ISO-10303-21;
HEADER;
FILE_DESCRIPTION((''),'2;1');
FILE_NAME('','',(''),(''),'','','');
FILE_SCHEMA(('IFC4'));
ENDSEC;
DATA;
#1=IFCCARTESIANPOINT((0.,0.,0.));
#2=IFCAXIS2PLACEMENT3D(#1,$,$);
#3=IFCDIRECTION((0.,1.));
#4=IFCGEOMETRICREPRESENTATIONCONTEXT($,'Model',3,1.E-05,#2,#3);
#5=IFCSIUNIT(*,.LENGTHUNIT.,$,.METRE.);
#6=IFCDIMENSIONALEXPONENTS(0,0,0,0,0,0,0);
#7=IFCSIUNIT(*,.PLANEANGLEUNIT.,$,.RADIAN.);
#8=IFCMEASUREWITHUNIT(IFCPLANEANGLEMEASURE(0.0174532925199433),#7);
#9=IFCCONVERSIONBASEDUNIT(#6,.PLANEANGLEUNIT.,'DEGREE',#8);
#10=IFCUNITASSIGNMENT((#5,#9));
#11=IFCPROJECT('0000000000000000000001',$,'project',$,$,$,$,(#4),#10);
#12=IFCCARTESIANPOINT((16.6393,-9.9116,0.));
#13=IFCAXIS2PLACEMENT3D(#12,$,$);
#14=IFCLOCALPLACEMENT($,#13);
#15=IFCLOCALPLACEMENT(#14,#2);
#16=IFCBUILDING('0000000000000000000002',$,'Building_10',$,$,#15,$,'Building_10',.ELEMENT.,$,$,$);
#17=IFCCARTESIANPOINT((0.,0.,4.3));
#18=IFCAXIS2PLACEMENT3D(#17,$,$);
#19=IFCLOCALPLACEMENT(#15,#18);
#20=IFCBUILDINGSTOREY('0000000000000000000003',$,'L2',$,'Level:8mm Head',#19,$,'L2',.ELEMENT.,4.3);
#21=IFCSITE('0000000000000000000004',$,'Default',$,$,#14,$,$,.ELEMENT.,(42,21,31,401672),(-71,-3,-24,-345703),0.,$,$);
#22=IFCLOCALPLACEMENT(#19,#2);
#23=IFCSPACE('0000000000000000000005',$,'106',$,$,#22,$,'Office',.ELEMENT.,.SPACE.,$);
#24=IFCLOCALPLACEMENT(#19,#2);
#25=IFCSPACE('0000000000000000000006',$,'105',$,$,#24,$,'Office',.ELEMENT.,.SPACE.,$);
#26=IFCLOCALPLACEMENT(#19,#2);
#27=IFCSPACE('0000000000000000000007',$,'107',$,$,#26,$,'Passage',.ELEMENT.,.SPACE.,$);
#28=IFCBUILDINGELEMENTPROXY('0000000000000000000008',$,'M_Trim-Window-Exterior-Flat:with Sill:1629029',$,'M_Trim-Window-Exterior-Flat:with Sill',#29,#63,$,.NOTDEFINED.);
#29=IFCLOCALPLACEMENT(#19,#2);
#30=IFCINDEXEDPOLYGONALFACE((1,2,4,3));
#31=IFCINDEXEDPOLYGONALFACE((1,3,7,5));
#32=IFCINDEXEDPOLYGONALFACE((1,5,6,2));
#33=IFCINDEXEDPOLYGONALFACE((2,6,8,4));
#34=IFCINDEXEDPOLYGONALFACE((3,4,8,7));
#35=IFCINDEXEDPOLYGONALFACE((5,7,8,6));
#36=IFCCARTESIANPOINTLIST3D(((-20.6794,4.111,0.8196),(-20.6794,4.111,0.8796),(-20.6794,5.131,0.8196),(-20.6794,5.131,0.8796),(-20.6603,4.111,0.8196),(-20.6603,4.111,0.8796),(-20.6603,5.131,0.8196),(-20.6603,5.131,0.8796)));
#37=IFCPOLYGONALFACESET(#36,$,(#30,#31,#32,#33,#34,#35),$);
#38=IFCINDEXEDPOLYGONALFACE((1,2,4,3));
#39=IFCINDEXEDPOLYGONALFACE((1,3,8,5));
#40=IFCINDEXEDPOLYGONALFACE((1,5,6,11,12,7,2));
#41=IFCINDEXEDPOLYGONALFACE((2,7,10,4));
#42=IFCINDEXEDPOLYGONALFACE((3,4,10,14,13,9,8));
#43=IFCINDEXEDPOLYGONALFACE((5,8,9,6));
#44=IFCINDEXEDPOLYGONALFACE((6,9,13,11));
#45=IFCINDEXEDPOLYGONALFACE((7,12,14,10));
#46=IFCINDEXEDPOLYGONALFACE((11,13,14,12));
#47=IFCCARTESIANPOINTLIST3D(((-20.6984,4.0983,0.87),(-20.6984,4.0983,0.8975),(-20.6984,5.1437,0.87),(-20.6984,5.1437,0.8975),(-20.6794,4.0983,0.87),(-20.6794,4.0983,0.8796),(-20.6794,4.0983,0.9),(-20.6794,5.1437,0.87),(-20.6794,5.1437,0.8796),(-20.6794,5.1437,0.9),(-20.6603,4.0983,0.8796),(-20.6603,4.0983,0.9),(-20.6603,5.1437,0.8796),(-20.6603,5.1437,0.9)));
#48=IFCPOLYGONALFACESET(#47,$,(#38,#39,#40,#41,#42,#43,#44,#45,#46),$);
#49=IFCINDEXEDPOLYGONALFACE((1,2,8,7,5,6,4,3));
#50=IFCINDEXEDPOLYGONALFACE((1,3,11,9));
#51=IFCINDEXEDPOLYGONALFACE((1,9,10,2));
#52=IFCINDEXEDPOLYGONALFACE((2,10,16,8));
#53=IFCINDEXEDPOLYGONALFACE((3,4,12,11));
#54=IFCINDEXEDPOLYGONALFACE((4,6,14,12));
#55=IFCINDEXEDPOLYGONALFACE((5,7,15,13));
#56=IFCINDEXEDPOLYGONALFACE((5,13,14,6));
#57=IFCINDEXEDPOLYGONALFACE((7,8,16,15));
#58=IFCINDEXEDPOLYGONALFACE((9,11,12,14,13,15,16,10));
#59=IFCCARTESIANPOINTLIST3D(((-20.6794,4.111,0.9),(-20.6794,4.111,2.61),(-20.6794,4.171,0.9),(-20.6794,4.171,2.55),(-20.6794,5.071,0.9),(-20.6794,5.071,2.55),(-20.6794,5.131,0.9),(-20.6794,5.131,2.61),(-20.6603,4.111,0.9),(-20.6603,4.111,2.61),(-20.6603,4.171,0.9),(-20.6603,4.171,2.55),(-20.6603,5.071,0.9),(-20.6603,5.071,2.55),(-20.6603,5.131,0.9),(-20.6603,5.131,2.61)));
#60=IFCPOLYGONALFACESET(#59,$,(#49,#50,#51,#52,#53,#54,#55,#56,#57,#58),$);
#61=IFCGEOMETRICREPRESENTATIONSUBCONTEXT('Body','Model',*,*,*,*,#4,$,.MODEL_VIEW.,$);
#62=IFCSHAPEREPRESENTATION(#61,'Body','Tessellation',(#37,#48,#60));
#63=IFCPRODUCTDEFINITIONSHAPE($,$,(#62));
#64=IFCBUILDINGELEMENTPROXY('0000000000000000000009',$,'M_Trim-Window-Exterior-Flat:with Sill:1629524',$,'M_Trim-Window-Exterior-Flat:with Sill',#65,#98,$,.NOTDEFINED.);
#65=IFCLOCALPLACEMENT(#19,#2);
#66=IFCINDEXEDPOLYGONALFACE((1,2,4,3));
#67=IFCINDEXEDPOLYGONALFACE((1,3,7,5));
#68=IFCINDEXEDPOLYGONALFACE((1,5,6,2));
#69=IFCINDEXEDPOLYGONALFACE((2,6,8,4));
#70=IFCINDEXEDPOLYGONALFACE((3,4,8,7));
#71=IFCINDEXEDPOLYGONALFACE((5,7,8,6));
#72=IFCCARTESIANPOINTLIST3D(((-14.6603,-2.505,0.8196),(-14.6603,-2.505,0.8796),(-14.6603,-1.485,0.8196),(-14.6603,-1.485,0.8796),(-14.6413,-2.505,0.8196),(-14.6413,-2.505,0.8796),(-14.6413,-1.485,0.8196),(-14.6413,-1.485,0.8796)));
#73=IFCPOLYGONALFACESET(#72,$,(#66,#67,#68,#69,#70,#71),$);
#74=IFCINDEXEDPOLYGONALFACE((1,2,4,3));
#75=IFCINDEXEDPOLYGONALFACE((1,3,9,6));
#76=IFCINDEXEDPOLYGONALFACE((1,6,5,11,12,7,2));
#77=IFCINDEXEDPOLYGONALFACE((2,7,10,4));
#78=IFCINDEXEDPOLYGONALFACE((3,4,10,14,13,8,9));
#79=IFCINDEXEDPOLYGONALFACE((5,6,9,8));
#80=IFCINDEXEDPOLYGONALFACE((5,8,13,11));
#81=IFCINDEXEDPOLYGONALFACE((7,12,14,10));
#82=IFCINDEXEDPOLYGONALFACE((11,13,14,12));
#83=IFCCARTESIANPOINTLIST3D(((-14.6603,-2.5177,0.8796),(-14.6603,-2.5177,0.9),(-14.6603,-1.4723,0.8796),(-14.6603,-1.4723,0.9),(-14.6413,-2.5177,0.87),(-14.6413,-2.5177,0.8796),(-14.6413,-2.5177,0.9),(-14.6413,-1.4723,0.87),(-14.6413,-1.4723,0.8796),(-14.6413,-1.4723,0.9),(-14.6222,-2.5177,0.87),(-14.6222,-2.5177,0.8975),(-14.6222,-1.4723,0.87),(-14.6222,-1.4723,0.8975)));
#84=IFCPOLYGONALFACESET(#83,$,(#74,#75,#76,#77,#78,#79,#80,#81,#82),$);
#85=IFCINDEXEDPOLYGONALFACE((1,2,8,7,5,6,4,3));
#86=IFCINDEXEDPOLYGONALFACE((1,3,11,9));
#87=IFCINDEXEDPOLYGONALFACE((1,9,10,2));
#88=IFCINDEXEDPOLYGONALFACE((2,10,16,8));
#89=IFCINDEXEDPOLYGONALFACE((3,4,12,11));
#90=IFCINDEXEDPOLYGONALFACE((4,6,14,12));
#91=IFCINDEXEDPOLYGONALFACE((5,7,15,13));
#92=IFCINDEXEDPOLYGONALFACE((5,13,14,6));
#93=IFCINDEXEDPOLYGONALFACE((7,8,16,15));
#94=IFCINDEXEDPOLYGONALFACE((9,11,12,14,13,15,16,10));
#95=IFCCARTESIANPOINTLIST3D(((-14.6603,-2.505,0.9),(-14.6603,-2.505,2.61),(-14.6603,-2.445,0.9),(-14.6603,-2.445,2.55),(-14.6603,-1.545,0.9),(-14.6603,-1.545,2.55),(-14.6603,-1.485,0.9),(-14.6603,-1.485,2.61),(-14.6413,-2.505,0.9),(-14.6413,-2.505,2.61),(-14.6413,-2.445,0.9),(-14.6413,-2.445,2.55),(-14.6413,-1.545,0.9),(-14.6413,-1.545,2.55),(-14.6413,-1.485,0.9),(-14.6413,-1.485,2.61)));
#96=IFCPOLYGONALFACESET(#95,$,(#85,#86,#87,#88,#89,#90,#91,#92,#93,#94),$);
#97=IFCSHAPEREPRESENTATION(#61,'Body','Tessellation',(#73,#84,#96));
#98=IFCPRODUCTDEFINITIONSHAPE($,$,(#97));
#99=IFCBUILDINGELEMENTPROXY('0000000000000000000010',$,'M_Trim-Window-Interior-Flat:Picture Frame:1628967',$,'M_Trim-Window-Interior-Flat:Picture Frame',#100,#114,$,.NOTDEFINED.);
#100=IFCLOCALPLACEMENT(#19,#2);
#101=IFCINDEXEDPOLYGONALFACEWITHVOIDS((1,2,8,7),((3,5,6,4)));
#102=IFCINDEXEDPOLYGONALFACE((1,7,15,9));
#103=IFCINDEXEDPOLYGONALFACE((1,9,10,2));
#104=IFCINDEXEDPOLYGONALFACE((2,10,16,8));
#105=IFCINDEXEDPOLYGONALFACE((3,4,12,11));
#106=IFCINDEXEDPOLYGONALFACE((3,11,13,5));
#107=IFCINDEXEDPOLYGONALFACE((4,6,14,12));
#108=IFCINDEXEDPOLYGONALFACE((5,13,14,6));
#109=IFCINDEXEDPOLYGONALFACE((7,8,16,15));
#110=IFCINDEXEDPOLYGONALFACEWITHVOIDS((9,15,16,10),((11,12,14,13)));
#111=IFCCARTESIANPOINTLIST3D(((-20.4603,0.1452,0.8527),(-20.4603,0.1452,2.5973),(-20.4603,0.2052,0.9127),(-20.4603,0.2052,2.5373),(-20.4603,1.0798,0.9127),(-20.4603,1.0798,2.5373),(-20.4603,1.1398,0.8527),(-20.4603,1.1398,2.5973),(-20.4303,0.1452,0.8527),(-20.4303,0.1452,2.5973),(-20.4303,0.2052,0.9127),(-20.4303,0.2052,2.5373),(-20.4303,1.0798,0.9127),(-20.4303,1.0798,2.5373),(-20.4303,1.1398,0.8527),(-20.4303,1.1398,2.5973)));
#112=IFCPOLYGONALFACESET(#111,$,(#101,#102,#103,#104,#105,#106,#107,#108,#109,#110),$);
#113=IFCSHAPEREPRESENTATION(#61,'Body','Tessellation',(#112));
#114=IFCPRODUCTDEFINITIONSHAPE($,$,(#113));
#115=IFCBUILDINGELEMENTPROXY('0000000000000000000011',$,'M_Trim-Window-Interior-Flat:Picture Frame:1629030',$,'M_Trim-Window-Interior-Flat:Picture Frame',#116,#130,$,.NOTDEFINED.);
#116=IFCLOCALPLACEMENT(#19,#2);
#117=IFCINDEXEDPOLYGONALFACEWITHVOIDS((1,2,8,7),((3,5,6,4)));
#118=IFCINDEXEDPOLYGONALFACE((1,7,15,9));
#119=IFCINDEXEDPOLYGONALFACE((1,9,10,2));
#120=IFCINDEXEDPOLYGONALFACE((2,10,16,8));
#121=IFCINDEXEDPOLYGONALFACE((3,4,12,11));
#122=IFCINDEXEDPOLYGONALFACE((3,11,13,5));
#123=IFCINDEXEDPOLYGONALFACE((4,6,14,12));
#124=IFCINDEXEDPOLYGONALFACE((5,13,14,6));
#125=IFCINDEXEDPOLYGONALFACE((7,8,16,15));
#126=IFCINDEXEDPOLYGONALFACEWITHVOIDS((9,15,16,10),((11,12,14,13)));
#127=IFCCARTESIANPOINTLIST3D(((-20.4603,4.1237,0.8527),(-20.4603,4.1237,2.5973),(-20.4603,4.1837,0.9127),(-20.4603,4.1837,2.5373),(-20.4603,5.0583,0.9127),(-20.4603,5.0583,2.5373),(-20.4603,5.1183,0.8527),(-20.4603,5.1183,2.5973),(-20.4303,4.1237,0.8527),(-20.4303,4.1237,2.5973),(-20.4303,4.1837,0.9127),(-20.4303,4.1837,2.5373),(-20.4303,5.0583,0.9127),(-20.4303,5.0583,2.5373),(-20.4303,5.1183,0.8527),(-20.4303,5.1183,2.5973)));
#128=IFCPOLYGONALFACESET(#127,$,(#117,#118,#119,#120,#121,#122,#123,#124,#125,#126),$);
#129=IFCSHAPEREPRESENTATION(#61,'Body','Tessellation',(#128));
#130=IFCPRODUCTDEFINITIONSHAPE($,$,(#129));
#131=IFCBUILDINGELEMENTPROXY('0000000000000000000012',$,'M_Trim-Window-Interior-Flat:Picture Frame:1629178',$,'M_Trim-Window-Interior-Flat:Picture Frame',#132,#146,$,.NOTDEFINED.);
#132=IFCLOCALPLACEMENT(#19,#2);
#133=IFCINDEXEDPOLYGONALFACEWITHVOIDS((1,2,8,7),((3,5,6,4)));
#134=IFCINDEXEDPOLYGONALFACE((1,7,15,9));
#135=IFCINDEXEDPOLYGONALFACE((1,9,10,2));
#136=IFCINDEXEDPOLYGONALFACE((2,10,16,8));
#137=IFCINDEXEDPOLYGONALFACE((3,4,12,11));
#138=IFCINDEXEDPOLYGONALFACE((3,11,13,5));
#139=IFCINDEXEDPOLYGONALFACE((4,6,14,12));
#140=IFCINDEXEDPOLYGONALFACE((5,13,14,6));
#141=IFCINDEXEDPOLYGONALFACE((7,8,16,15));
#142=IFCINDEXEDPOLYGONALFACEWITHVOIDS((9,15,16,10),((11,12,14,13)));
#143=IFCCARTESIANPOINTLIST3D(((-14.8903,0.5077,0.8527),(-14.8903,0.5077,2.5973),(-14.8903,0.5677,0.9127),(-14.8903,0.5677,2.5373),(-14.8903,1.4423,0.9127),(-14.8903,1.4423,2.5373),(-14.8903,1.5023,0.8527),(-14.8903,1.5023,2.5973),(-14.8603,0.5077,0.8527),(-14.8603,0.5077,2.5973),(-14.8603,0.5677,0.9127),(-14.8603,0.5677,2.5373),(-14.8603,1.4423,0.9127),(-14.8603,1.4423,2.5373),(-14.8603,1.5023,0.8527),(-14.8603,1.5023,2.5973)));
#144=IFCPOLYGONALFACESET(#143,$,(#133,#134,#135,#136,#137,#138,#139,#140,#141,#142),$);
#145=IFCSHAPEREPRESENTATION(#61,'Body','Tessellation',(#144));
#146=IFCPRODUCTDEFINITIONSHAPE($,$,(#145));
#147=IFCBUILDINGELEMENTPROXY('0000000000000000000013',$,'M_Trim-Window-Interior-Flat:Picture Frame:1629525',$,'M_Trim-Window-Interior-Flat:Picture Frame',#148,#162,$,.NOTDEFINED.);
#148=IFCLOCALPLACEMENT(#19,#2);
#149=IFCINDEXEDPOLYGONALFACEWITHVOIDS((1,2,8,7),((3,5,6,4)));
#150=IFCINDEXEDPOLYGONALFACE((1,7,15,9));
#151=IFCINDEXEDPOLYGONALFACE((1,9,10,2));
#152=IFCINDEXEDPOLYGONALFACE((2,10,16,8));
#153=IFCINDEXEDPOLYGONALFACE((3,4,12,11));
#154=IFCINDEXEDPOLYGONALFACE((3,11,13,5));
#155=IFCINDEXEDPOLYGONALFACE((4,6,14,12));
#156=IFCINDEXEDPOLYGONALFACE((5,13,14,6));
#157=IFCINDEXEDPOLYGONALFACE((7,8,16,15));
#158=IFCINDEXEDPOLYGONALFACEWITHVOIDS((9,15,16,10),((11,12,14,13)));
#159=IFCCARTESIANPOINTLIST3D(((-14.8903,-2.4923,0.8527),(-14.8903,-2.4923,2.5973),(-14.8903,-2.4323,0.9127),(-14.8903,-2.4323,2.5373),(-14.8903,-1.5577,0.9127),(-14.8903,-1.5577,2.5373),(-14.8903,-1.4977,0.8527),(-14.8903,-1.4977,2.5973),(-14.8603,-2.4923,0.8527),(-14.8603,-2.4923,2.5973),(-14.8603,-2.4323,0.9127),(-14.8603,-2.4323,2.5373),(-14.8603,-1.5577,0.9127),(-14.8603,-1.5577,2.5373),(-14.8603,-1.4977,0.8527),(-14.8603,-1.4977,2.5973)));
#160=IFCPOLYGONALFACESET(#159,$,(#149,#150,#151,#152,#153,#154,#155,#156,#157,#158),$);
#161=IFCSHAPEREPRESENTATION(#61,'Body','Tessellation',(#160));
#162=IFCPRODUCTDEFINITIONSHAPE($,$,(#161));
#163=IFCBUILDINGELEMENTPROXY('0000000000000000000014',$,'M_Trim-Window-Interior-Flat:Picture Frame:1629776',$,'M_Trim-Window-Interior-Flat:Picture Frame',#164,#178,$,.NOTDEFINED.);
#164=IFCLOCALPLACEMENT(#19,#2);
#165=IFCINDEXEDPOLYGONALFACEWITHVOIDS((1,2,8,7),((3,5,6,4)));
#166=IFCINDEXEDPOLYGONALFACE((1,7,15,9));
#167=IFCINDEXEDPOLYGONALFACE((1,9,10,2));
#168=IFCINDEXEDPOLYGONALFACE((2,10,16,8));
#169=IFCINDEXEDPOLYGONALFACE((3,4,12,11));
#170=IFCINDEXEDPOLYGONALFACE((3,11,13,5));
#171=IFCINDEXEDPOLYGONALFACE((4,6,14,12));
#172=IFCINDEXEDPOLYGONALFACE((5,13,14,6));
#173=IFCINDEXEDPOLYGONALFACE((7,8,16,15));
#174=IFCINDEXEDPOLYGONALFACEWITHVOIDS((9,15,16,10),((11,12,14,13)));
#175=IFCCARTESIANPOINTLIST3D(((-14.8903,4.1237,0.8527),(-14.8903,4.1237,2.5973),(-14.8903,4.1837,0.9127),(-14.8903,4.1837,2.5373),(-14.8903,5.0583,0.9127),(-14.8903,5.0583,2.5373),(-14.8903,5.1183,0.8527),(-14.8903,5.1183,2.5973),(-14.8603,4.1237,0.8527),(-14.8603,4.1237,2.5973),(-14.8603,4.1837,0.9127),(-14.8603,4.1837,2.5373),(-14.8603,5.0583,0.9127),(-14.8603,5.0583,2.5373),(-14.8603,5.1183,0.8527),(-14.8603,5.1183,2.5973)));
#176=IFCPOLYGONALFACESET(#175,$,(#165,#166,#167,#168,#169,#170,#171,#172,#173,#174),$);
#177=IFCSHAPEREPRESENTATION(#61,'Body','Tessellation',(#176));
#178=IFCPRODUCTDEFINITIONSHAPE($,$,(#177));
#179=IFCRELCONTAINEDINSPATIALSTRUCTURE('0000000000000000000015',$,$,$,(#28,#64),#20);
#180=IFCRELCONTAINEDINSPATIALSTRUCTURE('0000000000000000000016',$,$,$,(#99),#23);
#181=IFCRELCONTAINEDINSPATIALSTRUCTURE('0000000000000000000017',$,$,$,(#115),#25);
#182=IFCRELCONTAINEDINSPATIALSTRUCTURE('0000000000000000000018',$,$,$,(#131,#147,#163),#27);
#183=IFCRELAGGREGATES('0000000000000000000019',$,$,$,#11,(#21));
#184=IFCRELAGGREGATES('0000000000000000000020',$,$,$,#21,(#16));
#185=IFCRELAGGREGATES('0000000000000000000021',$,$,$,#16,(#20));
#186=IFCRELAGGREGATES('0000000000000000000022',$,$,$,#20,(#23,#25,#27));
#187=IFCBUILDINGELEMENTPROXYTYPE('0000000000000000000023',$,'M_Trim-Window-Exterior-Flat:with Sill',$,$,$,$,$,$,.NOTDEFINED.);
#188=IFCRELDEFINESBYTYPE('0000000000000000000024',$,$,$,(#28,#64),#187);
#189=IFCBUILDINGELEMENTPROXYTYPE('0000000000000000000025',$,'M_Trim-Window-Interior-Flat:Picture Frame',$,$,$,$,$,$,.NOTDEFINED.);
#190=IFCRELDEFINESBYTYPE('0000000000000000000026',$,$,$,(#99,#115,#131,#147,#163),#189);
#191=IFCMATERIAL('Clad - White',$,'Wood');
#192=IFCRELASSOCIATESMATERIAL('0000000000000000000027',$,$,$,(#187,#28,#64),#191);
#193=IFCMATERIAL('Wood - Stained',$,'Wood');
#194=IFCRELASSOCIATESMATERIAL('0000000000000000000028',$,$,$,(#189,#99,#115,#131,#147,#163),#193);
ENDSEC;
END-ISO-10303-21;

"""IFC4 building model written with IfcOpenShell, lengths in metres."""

from ifc_helpers import new_model, entity, si_unit, converted_unit, direction, frame, origin, place, context, subcontext, project, spatial, indexed_curve, outline, extrude, source, transform, mapped, material, type_object, type_shapes, element, save


model = new_model("IFC4")

# Units and contexts
model_context = context("Model", 3, precision=1e-05, world=origin(), true_north=direction((0.0, 1.0)))
body_context = subcontext(model_context, "Body", "Model", "MODEL_VIEW")
ifc_project = project(units=[si_unit("LENGTHUNIT", "METRE"), converted_unit("PLANEANGLEUNIT", "DEGREE", entity("IfcPlaneAngleMeasure", 0.0174532925199433), si_unit("PLANEANGLEUNIT", "RADIAN"), dimensions=[0, 0, 0, 0, 0, 0, 0])], contexts=[model_context])

# Site, building, storey
site_placement = place(None, frame((16.6393, -9.9116, 0.0)))
site = spatial("IfcSite", under=ifc_project, at=site_placement, Name="Default", CompositionType="ELEMENT", RefLatitude=(42, 21, 31, 401672), RefLongitude=(-71, -3, -24, -345703), RefElevation=0.0)
building_placement = place(site_placement, origin())
building = spatial("IfcBuilding", under=site, at=building_placement, Name="Building_10", LongName="Building_10", CompositionType="ELEMENT")
storey_placement = place(building_placement, frame((0.0, 0.0, 4.3)))
storey = spatial("IfcBuildingStorey", under=building, at=storey_placement, Name="L2", ObjectType="Level:8mm Head", LongName="L2", CompositionType="ELEMENT", Elevation=4.3)

# Shared definitions
ifc_material_1 = material(Name="Clad - White", Category="Wood")
ifc_material_2 = material(Name="Wood - Stained", Category="Wood")

# Building element proxies
building_element_proxy_type_1 = type_object("IfcBuildingElementProxyType", Name="M_Trim-Window-Exterior-Flat:with Sill", PredefinedType="NOTDEFINED", material=ifc_material_1)
shared_shape_1 = source(origin(), body_context, "Body", "SweptSolid", [
    extrude(outline(indexed_curve([(-0.51, -0.03), (0.51, -0.03), (0.51, 0.03), (-0.51, 0.03), (-0.51, -0.03)], self_intersect=False)), frame((0.0, -1.7004, 0.0), z_axis=(0.0, 0.0, 1.0), x_axis=(-1.0, 0.0, 0.0)), (0.0, 0.0, 1.0), 0.0191),
    extrude(outline(indexed_curve([(-0.019, -0.0152), (0.0, -0.0152), (0.0, -0.0057), (0.019, -0.0057), (0.019, 0.0148), (0.0, 0.0148), (-0.019, 0.0123), (-0.019, -0.0152)], self_intersect=False)), frame((-0.5227, -1.6648, 0.019), z_axis=(1.0, 0.0, 0.0), x_axis=(0.0, 0.0, -1.0)), (0.0, 0.0, 1.0), 1.0454),
    extrude(outline(indexed_curve([(-0.87, -0.51), (0.84, -0.51), (0.84, -0.45), (-0.81, -0.45), (-0.81, 0.45), (0.84, 0.45), (0.84, 0.51), (-0.87, 0.51), (-0.87, -0.51)], self_intersect=False)), frame((0.0, -0.81, 0.0), z_axis=(0.0, 0.0, 1.0), x_axis=(0.0, -1.0, 0.0)), (0.0, 0.0, 1.0), 0.0191),
])
type_shapes(building_element_proxy_type_1, [shared_shape_1])
for number, where, z_axis, x_axis, name in (
    (1, (-20.6603, 4.621, 2.55), (-1.0, 0.0, 0.0), (0.0, -1.0, 0.0), "M_Trim-Window-Exterior-Flat:with Sill:1629029"),
    (2, (-14.6603, -1.995, 2.55), (1.0, 0.0, 0.0), (0.0, 1.0, 0.0), "M_Trim-Window-Exterior-Flat:with Sill:1629524"),
):
    element("IfcBuildingElementProxy", number, at=place(storey_placement, frame(where, z_axis=z_axis, x_axis=x_axis)), inside=storey, type_object=building_element_proxy_type_1, material=ifc_material_1, Name=name, ObjectType="M_Trim-Window-Exterior-Flat:with Sill", PredefinedType="NOTDEFINED", context=body_context, shape_type="MappedRepresentation", body=[
        mapped(shared_shape_1, transform((0.0, 0.0, 0.0), scale=1.0)),
    ])

# Shared definitions
space_1_placement = place(storey_placement, origin())
space_1 = spatial("IfcSpace", under=storey, at=space_1_placement, Name="106", LongName="Office", CompositionType="ELEMENT", PredefinedType="SPACE")

# Building element proxy
building_element_proxy_type_2 = type_object("IfcBuildingElementProxyType", Name="M_Trim-Window-Interior-Flat:Picture Frame", PredefinedType="NOTDEFINED", material=ifc_material_2)
shared_shape_2 = source(origin(), body_context, "Body", "SweptSolid", [
    extrude(outline(indexed_curve([(-0.4973, -0.8723), (0.4973, -0.8723), (0.4973, 0.8723), (-0.4973, 0.8723), (-0.4973, -0.8723)], self_intersect=False), holes=[indexed_curve([(-0.4373, -0.8123), (-0.4373, 0.8123), (0.4373, 0.8123), (0.4373, -0.8123), (-0.4373, -0.8123)], self_intersect=False)]), frame((0.0, -0.825, 0.0), z_axis=(0.0, 0.0, 1.0), x_axis=(-1.0, 0.0, 0.0)), (0.0, 0.0, 1.0), 0.03),
])
type_shapes(building_element_proxy_type_2, [shared_shape_2])
proxy_1_placement = place(space_1_placement, frame((-20.4603, 0.6425, 2.55), z_axis=(1.0, 0.0, 0.0), x_axis=(0.0, 1.0, 0.0)))
element("IfcBuildingElementProxy", 3, at=proxy_1_placement, inside=space_1, type_object=building_element_proxy_type_2, material=ifc_material_2, Name="M_Trim-Window-Interior-Flat:Picture Frame:1628967", ObjectType="M_Trim-Window-Interior-Flat:Picture Frame", PredefinedType="NOTDEFINED", context=body_context, shape_type="MappedRepresentation", body=[
    mapped(shared_shape_2, transform((0.0, 0.0, 0.0), scale=1.0)),
])

# Shared definitions
space_2_placement = place(storey_placement, origin())
space_2 = spatial("IfcSpace", under=storey, at=space_2_placement, Name="105", LongName="Office", CompositionType="ELEMENT", PredefinedType="SPACE")

# Building element proxy
proxy_2_placement = place(space_2_placement, frame((-20.4603, 4.621, 2.55), z_axis=(1.0, 0.0, 0.0), x_axis=(0.0, 1.0, 0.0)))
element("IfcBuildingElementProxy", 4, at=proxy_2_placement, inside=space_2, type_object=building_element_proxy_type_2, material=ifc_material_2, Name="M_Trim-Window-Interior-Flat:Picture Frame:1629030", ObjectType="M_Trim-Window-Interior-Flat:Picture Frame", PredefinedType="NOTDEFINED", context=body_context, shape_type="MappedRepresentation", body=[
    mapped(shared_shape_2, transform((0.0, 0.0, 0.0), scale=1.0)),
])

# Shared definitions
space_3_placement = place(storey_placement, origin())
space_3 = spatial("IfcSpace", under=storey, at=space_3_placement, Name="107", LongName="Passage", CompositionType="ELEMENT", PredefinedType="SPACE")

# Building element proxies
for number, where, z_axis, x_axis, name in (
    (5, (-14.8603, 1.005, 2.55), (-1.0, 0.0, 0.0), (0.0, -1.0, 0.0), "M_Trim-Window-Interior-Flat:Picture Frame:1629178"),
    (6, (-14.8603, -1.995, 2.55), (-1.0, 0.0, 0.0), (0.0, -1.0, 0.0), "M_Trim-Window-Interior-Flat:Picture Frame:1629525"),
    (7, (-14.8603, 4.621, 2.55), (-1.0, 0.0, 0.0), (0.0, -1.0, 0.0), "M_Trim-Window-Interior-Flat:Picture Frame:1629776"),
):
    element("IfcBuildingElementProxy", number, at=place(space_3_placement, frame(where, z_axis=z_axis, x_axis=x_axis)), inside=space_3, type_object=building_element_proxy_type_2, material=ifc_material_2, Name=name, ObjectType="M_Trim-Window-Interior-Flat:Picture Frame", PredefinedType="NOTDEFINED", context=body_context, shape_type="MappedRepresentation", body=[
        mapped(shared_shape_2, transform((0.0, 0.0, 0.0), scale=1.0)),
    ])

save(model, "model.ifc")
